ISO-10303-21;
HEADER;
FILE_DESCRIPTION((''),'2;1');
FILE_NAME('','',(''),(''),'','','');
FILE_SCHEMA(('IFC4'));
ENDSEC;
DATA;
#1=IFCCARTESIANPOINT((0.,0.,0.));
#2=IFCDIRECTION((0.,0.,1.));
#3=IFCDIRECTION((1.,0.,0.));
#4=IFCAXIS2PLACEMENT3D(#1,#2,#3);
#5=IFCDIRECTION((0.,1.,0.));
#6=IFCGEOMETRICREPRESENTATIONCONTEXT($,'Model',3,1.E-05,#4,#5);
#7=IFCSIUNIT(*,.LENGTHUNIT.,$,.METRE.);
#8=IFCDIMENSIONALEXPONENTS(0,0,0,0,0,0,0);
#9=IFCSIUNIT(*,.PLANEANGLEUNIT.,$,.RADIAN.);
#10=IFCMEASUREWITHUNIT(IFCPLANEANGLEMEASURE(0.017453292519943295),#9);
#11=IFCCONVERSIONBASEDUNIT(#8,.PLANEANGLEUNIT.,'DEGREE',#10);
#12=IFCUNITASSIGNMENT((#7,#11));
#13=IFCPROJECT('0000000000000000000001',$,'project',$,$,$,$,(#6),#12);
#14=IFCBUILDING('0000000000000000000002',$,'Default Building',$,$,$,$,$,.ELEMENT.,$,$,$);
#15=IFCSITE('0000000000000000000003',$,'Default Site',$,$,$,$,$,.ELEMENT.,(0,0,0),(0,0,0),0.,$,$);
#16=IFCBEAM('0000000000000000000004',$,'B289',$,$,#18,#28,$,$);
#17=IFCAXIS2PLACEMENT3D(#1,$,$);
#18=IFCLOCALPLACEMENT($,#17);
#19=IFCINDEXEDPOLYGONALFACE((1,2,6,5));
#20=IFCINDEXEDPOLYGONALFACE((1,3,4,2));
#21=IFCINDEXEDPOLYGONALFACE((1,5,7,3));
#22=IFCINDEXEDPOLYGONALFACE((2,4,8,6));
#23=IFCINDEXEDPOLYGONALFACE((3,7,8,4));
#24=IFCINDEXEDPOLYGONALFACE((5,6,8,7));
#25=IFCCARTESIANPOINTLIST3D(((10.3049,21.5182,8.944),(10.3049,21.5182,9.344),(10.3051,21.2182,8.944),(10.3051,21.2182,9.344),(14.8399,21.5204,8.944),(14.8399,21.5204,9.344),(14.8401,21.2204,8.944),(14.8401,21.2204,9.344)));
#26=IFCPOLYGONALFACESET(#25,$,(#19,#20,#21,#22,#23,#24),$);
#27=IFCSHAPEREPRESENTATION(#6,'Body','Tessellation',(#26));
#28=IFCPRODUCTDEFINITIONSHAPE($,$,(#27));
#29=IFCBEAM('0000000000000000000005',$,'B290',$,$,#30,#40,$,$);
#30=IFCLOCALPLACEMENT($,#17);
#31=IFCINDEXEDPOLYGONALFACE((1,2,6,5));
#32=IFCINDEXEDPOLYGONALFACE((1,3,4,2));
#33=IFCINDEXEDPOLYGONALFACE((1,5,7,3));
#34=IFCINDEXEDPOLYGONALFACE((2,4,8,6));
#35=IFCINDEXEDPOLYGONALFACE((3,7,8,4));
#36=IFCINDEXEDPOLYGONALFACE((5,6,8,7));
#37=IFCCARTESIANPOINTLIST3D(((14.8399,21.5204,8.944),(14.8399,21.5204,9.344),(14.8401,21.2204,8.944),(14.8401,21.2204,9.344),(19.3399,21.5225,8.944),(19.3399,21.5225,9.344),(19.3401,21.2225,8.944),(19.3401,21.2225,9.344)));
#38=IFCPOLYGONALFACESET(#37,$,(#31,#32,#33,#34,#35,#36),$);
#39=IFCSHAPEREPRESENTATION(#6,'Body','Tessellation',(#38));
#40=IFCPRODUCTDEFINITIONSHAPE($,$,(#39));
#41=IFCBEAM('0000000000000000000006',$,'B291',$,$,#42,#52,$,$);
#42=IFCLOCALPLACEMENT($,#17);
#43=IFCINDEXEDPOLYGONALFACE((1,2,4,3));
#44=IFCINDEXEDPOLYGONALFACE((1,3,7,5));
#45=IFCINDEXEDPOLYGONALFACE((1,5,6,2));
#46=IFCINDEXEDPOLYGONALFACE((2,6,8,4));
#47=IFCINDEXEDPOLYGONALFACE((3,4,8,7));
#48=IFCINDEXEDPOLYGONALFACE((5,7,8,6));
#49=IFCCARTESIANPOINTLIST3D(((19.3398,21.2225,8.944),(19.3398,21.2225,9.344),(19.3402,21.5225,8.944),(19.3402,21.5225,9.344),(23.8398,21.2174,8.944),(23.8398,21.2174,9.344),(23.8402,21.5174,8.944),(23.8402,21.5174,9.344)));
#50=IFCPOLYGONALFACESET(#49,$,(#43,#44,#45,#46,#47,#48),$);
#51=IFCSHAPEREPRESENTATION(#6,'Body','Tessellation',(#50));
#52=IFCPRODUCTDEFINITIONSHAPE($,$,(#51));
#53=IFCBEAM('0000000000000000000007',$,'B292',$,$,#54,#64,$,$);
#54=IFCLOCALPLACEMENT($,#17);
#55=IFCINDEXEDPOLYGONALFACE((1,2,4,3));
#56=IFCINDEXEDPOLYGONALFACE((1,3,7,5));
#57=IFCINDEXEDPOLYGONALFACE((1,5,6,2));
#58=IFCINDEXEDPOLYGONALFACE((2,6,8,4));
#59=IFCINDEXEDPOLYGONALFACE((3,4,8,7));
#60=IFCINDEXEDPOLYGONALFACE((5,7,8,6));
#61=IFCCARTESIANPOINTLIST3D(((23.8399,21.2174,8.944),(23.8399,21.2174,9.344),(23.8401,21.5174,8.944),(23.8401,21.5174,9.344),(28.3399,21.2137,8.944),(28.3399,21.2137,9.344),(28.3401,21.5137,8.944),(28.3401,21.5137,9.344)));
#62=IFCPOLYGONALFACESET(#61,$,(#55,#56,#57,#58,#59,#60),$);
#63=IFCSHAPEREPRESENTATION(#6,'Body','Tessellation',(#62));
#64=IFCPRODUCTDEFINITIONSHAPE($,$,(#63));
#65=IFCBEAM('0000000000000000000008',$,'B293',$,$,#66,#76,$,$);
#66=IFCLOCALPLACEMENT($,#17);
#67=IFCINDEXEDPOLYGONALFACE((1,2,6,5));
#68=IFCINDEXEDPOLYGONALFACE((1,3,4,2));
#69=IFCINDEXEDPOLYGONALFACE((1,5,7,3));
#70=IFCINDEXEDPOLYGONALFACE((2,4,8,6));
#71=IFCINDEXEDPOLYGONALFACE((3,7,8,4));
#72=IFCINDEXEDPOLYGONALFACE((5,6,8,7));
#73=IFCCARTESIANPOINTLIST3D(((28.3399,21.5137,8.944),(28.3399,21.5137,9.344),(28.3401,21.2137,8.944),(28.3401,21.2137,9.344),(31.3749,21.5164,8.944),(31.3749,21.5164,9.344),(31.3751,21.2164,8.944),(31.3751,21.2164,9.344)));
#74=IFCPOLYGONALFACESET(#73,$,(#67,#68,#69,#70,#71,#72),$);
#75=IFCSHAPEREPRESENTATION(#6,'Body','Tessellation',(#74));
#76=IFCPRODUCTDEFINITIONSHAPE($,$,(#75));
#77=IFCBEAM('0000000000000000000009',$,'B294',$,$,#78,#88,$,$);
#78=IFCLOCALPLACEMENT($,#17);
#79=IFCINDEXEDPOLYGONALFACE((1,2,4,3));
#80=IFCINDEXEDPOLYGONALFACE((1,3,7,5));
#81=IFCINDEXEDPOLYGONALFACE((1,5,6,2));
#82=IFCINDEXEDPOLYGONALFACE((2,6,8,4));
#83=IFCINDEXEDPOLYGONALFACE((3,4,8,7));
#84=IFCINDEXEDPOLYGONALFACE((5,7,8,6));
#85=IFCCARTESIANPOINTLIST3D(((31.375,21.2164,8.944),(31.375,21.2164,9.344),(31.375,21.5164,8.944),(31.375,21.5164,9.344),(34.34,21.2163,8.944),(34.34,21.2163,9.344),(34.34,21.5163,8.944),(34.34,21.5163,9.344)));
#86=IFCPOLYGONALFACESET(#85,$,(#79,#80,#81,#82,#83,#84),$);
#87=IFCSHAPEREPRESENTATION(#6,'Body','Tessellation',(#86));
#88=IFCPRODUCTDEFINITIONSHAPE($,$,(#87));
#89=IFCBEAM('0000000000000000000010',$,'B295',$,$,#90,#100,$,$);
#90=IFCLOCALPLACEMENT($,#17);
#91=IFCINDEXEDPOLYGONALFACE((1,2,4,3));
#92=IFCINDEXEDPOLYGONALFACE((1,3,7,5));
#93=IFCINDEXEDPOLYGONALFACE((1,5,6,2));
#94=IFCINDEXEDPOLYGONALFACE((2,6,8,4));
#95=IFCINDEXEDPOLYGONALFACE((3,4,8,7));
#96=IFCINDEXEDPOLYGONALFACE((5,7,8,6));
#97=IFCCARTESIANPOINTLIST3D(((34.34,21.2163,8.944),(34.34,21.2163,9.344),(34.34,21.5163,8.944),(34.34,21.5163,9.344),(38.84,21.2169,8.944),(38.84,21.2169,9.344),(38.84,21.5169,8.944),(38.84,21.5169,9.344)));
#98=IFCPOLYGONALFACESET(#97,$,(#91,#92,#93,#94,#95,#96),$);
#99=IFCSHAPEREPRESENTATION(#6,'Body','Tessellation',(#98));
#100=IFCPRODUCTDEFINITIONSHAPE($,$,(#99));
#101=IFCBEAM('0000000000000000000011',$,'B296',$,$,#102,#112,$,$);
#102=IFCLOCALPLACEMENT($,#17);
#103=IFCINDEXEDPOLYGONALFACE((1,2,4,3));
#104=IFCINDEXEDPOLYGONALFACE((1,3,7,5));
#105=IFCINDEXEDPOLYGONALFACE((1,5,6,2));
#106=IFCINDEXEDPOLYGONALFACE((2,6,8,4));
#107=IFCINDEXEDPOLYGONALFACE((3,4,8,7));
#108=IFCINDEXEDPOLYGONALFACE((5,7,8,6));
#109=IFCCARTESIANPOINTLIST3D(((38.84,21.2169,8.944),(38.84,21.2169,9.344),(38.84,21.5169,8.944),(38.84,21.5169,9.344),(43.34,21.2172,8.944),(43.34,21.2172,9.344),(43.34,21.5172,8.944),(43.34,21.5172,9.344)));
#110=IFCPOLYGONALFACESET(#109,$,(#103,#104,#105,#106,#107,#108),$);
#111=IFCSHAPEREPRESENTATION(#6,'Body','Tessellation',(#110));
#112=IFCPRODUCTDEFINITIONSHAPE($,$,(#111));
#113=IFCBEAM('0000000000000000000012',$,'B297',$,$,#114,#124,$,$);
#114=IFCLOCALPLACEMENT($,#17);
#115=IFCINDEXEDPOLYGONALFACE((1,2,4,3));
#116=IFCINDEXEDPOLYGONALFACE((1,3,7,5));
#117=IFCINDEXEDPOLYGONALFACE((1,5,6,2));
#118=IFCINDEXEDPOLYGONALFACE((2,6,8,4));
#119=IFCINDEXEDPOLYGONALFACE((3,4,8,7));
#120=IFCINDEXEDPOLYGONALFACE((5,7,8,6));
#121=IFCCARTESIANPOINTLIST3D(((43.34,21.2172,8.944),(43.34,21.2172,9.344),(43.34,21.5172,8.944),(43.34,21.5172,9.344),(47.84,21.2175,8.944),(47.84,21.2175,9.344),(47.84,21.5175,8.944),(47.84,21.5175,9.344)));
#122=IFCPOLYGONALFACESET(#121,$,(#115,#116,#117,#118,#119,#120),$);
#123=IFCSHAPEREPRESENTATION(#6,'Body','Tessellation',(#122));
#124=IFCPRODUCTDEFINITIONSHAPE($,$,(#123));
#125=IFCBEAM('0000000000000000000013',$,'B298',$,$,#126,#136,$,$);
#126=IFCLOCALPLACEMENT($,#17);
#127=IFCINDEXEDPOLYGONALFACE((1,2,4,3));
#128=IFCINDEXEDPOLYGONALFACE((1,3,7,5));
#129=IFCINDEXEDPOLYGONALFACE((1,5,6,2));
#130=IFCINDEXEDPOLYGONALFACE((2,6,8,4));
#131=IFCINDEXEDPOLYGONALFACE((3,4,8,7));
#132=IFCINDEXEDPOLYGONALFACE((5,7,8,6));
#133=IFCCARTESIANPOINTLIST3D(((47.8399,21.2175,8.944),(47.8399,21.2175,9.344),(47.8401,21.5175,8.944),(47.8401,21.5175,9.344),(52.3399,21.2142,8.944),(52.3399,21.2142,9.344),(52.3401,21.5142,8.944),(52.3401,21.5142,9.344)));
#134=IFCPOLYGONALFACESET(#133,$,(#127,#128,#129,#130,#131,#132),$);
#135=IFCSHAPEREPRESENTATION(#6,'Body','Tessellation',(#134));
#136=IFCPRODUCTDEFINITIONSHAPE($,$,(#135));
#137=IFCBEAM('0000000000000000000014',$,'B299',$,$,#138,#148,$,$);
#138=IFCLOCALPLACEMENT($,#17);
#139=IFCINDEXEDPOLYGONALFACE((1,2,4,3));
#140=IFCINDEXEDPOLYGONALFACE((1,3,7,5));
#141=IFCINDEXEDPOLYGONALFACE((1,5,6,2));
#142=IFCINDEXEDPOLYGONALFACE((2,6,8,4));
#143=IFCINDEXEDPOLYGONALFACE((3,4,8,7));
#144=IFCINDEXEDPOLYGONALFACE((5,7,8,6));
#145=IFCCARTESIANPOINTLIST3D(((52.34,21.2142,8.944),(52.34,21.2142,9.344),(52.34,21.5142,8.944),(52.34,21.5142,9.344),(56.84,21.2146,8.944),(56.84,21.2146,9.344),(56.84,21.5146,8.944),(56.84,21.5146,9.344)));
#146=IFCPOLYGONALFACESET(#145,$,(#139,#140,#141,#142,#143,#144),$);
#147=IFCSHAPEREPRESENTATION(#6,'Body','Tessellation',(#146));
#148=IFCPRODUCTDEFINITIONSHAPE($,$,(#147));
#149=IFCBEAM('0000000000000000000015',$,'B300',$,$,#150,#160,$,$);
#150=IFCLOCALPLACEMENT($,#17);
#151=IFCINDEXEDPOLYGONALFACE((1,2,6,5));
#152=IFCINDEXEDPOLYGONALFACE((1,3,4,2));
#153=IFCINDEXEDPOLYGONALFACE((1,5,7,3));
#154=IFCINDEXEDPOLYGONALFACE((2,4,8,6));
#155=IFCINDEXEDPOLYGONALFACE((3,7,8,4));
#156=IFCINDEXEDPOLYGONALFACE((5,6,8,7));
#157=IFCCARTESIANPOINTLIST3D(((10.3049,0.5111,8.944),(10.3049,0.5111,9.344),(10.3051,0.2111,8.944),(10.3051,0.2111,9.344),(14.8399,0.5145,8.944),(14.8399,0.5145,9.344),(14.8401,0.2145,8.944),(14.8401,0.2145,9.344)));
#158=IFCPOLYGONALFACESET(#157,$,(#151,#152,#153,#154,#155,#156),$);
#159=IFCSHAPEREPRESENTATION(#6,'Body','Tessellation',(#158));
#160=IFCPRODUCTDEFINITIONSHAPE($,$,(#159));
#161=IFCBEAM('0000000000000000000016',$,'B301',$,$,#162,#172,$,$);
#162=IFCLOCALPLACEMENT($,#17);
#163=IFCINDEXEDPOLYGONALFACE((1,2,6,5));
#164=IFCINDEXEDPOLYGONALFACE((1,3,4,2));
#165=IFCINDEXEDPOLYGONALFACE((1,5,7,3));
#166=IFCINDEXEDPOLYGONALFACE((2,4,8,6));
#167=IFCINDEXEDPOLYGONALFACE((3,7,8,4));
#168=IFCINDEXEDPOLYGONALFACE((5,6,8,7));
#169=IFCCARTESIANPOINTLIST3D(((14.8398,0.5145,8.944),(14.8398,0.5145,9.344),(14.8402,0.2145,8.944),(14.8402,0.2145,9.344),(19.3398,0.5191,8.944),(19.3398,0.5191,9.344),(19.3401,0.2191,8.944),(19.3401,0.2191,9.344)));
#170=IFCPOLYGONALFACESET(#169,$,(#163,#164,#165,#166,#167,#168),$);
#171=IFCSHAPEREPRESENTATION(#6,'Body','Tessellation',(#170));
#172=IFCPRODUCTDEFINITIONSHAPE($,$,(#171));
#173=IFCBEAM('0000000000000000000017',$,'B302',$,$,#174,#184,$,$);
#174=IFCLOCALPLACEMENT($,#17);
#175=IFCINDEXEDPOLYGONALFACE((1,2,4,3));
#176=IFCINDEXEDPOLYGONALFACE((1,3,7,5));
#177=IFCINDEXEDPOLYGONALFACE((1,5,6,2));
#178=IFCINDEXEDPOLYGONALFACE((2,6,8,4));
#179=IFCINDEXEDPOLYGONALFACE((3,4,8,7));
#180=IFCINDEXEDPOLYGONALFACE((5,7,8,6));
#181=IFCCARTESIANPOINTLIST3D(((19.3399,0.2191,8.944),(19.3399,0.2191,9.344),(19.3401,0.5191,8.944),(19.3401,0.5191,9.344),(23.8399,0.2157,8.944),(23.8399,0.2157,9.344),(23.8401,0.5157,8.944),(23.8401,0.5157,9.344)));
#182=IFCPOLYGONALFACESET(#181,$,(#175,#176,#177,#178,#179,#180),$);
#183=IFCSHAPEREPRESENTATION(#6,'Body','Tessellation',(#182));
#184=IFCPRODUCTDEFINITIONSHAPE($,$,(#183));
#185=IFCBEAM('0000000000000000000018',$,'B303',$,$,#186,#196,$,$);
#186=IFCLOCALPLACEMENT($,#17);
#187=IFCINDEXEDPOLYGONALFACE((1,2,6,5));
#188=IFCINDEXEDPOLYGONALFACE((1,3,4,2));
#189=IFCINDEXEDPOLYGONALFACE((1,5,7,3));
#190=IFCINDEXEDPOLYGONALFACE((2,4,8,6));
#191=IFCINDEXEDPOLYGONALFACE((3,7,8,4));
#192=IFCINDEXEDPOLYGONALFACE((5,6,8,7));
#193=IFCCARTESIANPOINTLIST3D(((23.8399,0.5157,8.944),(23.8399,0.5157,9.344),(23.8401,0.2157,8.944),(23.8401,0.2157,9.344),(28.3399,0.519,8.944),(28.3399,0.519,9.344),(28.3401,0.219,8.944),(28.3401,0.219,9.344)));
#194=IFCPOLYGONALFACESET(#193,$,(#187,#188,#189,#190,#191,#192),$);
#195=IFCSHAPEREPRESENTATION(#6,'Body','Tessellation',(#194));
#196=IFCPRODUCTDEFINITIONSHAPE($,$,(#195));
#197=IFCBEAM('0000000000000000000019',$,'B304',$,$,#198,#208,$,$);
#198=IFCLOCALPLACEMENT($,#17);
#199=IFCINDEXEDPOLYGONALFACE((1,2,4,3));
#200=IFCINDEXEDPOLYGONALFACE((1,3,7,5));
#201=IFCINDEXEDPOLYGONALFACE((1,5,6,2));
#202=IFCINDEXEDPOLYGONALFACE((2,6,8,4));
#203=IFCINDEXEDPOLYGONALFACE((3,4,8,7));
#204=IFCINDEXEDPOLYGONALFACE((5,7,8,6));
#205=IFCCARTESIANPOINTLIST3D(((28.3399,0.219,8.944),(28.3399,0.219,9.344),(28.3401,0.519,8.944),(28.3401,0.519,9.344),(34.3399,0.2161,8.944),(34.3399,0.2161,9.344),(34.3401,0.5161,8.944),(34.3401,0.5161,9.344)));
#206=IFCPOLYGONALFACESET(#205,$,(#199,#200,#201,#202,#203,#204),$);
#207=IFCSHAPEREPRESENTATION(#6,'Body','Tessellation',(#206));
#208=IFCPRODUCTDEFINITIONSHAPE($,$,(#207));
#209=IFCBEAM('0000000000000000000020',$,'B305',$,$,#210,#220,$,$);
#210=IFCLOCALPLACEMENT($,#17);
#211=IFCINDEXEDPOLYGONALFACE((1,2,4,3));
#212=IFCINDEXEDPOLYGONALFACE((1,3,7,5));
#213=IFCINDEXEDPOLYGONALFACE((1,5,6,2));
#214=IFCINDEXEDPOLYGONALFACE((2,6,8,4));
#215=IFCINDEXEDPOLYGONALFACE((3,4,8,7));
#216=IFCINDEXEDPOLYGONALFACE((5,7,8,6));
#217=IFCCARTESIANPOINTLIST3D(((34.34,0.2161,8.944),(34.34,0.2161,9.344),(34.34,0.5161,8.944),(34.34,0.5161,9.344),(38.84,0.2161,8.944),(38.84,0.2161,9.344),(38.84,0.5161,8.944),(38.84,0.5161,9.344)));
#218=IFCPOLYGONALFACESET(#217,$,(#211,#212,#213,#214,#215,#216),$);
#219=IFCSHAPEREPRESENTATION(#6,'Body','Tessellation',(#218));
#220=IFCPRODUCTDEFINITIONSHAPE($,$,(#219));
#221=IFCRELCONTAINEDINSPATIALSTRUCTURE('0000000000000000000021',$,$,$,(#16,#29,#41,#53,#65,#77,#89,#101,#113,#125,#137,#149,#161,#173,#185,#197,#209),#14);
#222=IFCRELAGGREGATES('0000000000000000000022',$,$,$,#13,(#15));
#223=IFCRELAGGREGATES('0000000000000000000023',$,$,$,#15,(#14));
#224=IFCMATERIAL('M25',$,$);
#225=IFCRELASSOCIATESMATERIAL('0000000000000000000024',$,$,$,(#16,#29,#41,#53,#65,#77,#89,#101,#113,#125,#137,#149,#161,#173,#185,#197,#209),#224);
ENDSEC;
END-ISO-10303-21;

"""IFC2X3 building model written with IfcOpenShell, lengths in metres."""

from ifc_helpers import new_model, entity, si_unit, converted_unit, direction, frame, frame_2d, origin_with_axes, place, context, project, spatial, rectangle, extrude, material, element, save


model = new_model("IFC2X3")

# Units and contexts
model_context = context("Model", 3, precision=1e-05, world=origin_with_axes(), true_north=direction((0.0, 1.0, 0.0)))
ifc_project = project(units=[si_unit("LENGTHUNIT", "METRE"), converted_unit("PLANEANGLEUNIT", "DEGREE", entity("IfcPlaneAngleMeasure", 0.017453292519943295), si_unit("PLANEANGLEUNIT", "RADIAN"), dimensions=[0, 0, 0, 0, 0, 0, 0])], contexts=[model_context])

# Site, building
site = spatial("IfcSite", under=ifc_project, Name="Default Site", CompositionType="ELEMENT", RefLatitude=(0, 0, 0), RefLongitude=(0, 0, 0), RefElevation=0.0)
building = spatial("IfcBuilding", under=site, Name="Default Building", CompositionType="ELEMENT")

# Beams
ifc_material = material(Name="M25")
placement = place(None, origin_with_axes())
element("IfcBeam", 1, at=placement, inside=building, material=ifc_material, Name="B289", context=model_context, shape_type="SweptSolid", body=[
    extrude(rectangle(XDim=0.3, YDim=0.4, at=frame_2d((0.0, 0.0), x_axis=(0.0, 1.0, 0.0))), frame((10.305, 21.3682, 9.144), z_axis=(1.0, 0.000476, 0.0), x_axis=(0.0, 0.0, -1.0)), (0.0, 0.0, 1.0), 4.535),
])
element("IfcBeam", 2, at=placement, inside=building, material=ifc_material, Name="B290", context=model_context, shape_type="SweptSolid", body=[
    extrude(rectangle(XDim=0.3, YDim=0.4, at=frame_2d((0.0, 0.0), x_axis=(0.0, 1.0, 0.0))), frame((14.84, 21.3704, 9.144), z_axis=(1.0, 0.000471, 0.0), x_axis=(0.0, 0.0, -1.0)), (0.0, 0.0, 1.0), 4.5),
])
element("IfcBeam", 3, at=placement, inside=building, material=ifc_material, Name="B291", context=model_context, shape_type="SweptSolid", body=[
    extrude(rectangle(XDim=0.3, YDim=0.4, at=frame_2d((0.0, 0.0), x_axis=(0.0, 1.0, 0.0))), frame((19.34, 21.3725, 9.144), z_axis=(0.999999, -0.001141, 0.0), x_axis=(0.0, 0.0, -1.0)), (0.0, 0.0, 1.0), 4.5),
])
element("IfcBeam", 4, at=placement, inside=building, material=ifc_material, Name="B292", context=model_context, shape_type="SweptSolid", body=[
    extrude(rectangle(XDim=0.3, YDim=0.4, at=frame_2d((0.0, 0.0), x_axis=(0.0, 1.0, 0.0))), frame((23.84, 21.3674, 9.144), z_axis=(1.0, -0.000812, 0.0), x_axis=(0.0, 0.0, -1.0)), (0.0, 0.0, 1.0), 4.5),
])
element("IfcBeam", 5, at=placement, inside=building, material=ifc_material, Name="B293", context=model_context, shape_type="SweptSolid", body=[
    extrude(rectangle(XDim=0.3, YDim=0.4, at=frame_2d((0.0, 0.0), x_axis=(0.0, 1.0, 0.0))), frame((28.34, 21.3637, 9.144), z_axis=(1.0, 0.000883, 0.0), x_axis=(0.0, 0.0, -1.0)), (0.0, 0.0, 1.0), 3.035),
])
element("IfcBeam", 6, at=placement, inside=building, material=ifc_material, Name="B294", context=model_context, shape_type="SweptSolid", body=[
    extrude(rectangle(XDim=0.3, YDim=0.4, at=frame_2d((0.0, 0.0), x_axis=(0.0, 1.0, 0.0))), frame((31.375, 21.3664, 9.144), z_axis=(1.0, -0.000016, 0.0), x_axis=(0.0, 0.0, -1.0)), (0.0, 0.0, 1.0), 2.965),
])
element("IfcBeam", 7, at=placement, inside=building, material=ifc_material, Name="B295", context=model_context, shape_type="SweptSolid", body=[
    extrude(rectangle(XDim=0.3, YDim=0.4, at=frame_2d((0.0, 0.0), x_axis=(0.0, 1.0, 0.0))), frame((34.34, 21.3663, 9.144), z_axis=(1.0, 0.000136, 0.0), x_axis=(0.0, 0.0, -1.0)), (0.0, 0.0, 1.0), 4.5),
])
element("IfcBeam", 8, at=placement, inside=building, material=ifc_material, Name="B296", context=model_context, shape_type="SweptSolid", body=[
    extrude(rectangle(XDim=0.3, YDim=0.4, at=frame_2d((0.0, 0.0), x_axis=(0.0, 1.0, 0.0))), frame((38.84, 21.3669, 9.144), z_axis=(1.0, 0.00005, 0.0), x_axis=(0.0, 0.0, -1.0)), (0.0, 0.0, 1.0), 4.5),
])
element("IfcBeam", 9, at=placement, inside=building, material=ifc_material, Name="B297", context=model_context, shape_type="SweptSolid", body=[
    extrude(rectangle(XDim=0.3, YDim=0.4, at=frame_2d((0.0, 0.0), x_axis=(0.0, 1.0, 0.0))), frame((43.34, 21.3672, 9.144), z_axis=(1.0, 0.000075, 0.0), x_axis=(0.0, 0.0, -1.0)), (0.0, 0.0, 1.0), 4.5),
])
element("IfcBeam", 10, at=placement, inside=building, material=ifc_material, Name="B298", context=model_context, shape_type="SweptSolid", body=[
    extrude(rectangle(XDim=0.3, YDim=0.4, at=frame_2d((0.0, 0.0), x_axis=(0.0, 1.0, 0.0))), frame((47.84, 21.3675, 9.144), z_axis=(1.0, -0.000744, 0.0), x_axis=(0.0, 0.0, -1.0)), (0.0, 0.0, 1.0), 4.5),
])
element("IfcBeam", 11, at=placement, inside=building, material=ifc_material, Name="B299", context=model_context, shape_type="SweptSolid", body=[
    extrude(rectangle(XDim=0.3, YDim=0.4, at=frame_2d((0.0, 0.0), x_axis=(0.0, 1.0, 0.0))), frame((52.34, 21.3642, 9.144), z_axis=(1.0, 0.000102, 0.0), x_axis=(0.0, 0.0, -1.0)), (0.0, 0.0, 1.0), 4.5),
])
element("IfcBeam", 12, at=placement, inside=building, material=ifc_material, Name="B300", context=model_context, shape_type="SweptSolid", body=[
    extrude(rectangle(XDim=0.3, YDim=0.4, at=frame_2d((0.0, 0.0), x_axis=(0.0, 1.0, 0.0))), frame((10.305, 0.3611, 9.144), z_axis=(1.0, 0.000762, 0.0), x_axis=(0.0, 0.0, -1.0)), (0.0, 0.0, 1.0), 4.535),
])
element("IfcBeam", 13, at=placement, inside=building, material=ifc_material, Name="B301", context=model_context, shape_type="SweptSolid", body=[
    extrude(rectangle(XDim=0.3, YDim=0.4, at=frame_2d((0.0, 0.0), x_axis=(0.0, 1.0, 0.0))), frame((14.84, 0.3645, 9.144), z_axis=(0.999999, 0.00101, 0.0), x_axis=(0.0, 0.0, -1.0)), (0.0, 0.0, 1.0), 4.5),
])
element("IfcBeam", 14, at=placement, inside=building, material=ifc_material, Name="B302", context=model_context, shape_type="SweptSolid", body=[
    extrude(rectangle(XDim=0.3, YDim=0.4, at=frame_2d((0.0, 0.0), x_axis=(0.0, 1.0, 0.0))), frame((19.34, 0.3691, 9.144), z_axis=(1.0, -0.000757, 0.0), x_axis=(0.0, 0.0, -1.0)), (0.0, 0.0, 1.0), 4.5),
])
element("IfcBeam", 15, at=placement, inside=building, material=ifc_material, Name="B303", context=model_context, shape_type="SweptSolid", body=[
    extrude(rectangle(XDim=0.3, YDim=0.4, at=frame_2d((0.0, 0.0), x_axis=(0.0, 1.0, 0.0))), frame((23.84, 0.3657, 9.144), z_axis=(1.0, 0.00075, 0.0), x_axis=(0.0, 0.0, -1.0)), (0.0, 0.0, 1.0), 4.5),
])
element("IfcBeam", 16, at=placement, inside=building, material=ifc_material, Name="B304", context=model_context, shape_type="SweptSolid", body=[
    extrude(rectangle(XDim=0.3, YDim=0.4, at=frame_2d((0.0, 0.0), x_axis=(0.0, 1.0, 0.0))), frame((28.34, 0.369, 9.144), z_axis=(1.0, -0.000487, 0.0), x_axis=(0.0, 0.0, -1.0)), (0.0, 0.0, 1.0), 6.0),
])
element("IfcBeam", 17, at=placement, inside=building, material=ifc_material, Name="B305", context=model_context, shape_type="SweptSolid", body=[
    extrude(rectangle(XDim=0.3, YDim=0.4, at=frame_2d((0.0, 0.0), x_axis=(0.0, 1.0, 0.0))), frame((34.34, 0.3661, 9.144), z_axis=(1.0, 0.000003, 0.0), x_axis=(0.0, 0.0, -1.0)), (0.0, 0.0, 1.0), 4.5),
])

save(model, "model.ifc")
